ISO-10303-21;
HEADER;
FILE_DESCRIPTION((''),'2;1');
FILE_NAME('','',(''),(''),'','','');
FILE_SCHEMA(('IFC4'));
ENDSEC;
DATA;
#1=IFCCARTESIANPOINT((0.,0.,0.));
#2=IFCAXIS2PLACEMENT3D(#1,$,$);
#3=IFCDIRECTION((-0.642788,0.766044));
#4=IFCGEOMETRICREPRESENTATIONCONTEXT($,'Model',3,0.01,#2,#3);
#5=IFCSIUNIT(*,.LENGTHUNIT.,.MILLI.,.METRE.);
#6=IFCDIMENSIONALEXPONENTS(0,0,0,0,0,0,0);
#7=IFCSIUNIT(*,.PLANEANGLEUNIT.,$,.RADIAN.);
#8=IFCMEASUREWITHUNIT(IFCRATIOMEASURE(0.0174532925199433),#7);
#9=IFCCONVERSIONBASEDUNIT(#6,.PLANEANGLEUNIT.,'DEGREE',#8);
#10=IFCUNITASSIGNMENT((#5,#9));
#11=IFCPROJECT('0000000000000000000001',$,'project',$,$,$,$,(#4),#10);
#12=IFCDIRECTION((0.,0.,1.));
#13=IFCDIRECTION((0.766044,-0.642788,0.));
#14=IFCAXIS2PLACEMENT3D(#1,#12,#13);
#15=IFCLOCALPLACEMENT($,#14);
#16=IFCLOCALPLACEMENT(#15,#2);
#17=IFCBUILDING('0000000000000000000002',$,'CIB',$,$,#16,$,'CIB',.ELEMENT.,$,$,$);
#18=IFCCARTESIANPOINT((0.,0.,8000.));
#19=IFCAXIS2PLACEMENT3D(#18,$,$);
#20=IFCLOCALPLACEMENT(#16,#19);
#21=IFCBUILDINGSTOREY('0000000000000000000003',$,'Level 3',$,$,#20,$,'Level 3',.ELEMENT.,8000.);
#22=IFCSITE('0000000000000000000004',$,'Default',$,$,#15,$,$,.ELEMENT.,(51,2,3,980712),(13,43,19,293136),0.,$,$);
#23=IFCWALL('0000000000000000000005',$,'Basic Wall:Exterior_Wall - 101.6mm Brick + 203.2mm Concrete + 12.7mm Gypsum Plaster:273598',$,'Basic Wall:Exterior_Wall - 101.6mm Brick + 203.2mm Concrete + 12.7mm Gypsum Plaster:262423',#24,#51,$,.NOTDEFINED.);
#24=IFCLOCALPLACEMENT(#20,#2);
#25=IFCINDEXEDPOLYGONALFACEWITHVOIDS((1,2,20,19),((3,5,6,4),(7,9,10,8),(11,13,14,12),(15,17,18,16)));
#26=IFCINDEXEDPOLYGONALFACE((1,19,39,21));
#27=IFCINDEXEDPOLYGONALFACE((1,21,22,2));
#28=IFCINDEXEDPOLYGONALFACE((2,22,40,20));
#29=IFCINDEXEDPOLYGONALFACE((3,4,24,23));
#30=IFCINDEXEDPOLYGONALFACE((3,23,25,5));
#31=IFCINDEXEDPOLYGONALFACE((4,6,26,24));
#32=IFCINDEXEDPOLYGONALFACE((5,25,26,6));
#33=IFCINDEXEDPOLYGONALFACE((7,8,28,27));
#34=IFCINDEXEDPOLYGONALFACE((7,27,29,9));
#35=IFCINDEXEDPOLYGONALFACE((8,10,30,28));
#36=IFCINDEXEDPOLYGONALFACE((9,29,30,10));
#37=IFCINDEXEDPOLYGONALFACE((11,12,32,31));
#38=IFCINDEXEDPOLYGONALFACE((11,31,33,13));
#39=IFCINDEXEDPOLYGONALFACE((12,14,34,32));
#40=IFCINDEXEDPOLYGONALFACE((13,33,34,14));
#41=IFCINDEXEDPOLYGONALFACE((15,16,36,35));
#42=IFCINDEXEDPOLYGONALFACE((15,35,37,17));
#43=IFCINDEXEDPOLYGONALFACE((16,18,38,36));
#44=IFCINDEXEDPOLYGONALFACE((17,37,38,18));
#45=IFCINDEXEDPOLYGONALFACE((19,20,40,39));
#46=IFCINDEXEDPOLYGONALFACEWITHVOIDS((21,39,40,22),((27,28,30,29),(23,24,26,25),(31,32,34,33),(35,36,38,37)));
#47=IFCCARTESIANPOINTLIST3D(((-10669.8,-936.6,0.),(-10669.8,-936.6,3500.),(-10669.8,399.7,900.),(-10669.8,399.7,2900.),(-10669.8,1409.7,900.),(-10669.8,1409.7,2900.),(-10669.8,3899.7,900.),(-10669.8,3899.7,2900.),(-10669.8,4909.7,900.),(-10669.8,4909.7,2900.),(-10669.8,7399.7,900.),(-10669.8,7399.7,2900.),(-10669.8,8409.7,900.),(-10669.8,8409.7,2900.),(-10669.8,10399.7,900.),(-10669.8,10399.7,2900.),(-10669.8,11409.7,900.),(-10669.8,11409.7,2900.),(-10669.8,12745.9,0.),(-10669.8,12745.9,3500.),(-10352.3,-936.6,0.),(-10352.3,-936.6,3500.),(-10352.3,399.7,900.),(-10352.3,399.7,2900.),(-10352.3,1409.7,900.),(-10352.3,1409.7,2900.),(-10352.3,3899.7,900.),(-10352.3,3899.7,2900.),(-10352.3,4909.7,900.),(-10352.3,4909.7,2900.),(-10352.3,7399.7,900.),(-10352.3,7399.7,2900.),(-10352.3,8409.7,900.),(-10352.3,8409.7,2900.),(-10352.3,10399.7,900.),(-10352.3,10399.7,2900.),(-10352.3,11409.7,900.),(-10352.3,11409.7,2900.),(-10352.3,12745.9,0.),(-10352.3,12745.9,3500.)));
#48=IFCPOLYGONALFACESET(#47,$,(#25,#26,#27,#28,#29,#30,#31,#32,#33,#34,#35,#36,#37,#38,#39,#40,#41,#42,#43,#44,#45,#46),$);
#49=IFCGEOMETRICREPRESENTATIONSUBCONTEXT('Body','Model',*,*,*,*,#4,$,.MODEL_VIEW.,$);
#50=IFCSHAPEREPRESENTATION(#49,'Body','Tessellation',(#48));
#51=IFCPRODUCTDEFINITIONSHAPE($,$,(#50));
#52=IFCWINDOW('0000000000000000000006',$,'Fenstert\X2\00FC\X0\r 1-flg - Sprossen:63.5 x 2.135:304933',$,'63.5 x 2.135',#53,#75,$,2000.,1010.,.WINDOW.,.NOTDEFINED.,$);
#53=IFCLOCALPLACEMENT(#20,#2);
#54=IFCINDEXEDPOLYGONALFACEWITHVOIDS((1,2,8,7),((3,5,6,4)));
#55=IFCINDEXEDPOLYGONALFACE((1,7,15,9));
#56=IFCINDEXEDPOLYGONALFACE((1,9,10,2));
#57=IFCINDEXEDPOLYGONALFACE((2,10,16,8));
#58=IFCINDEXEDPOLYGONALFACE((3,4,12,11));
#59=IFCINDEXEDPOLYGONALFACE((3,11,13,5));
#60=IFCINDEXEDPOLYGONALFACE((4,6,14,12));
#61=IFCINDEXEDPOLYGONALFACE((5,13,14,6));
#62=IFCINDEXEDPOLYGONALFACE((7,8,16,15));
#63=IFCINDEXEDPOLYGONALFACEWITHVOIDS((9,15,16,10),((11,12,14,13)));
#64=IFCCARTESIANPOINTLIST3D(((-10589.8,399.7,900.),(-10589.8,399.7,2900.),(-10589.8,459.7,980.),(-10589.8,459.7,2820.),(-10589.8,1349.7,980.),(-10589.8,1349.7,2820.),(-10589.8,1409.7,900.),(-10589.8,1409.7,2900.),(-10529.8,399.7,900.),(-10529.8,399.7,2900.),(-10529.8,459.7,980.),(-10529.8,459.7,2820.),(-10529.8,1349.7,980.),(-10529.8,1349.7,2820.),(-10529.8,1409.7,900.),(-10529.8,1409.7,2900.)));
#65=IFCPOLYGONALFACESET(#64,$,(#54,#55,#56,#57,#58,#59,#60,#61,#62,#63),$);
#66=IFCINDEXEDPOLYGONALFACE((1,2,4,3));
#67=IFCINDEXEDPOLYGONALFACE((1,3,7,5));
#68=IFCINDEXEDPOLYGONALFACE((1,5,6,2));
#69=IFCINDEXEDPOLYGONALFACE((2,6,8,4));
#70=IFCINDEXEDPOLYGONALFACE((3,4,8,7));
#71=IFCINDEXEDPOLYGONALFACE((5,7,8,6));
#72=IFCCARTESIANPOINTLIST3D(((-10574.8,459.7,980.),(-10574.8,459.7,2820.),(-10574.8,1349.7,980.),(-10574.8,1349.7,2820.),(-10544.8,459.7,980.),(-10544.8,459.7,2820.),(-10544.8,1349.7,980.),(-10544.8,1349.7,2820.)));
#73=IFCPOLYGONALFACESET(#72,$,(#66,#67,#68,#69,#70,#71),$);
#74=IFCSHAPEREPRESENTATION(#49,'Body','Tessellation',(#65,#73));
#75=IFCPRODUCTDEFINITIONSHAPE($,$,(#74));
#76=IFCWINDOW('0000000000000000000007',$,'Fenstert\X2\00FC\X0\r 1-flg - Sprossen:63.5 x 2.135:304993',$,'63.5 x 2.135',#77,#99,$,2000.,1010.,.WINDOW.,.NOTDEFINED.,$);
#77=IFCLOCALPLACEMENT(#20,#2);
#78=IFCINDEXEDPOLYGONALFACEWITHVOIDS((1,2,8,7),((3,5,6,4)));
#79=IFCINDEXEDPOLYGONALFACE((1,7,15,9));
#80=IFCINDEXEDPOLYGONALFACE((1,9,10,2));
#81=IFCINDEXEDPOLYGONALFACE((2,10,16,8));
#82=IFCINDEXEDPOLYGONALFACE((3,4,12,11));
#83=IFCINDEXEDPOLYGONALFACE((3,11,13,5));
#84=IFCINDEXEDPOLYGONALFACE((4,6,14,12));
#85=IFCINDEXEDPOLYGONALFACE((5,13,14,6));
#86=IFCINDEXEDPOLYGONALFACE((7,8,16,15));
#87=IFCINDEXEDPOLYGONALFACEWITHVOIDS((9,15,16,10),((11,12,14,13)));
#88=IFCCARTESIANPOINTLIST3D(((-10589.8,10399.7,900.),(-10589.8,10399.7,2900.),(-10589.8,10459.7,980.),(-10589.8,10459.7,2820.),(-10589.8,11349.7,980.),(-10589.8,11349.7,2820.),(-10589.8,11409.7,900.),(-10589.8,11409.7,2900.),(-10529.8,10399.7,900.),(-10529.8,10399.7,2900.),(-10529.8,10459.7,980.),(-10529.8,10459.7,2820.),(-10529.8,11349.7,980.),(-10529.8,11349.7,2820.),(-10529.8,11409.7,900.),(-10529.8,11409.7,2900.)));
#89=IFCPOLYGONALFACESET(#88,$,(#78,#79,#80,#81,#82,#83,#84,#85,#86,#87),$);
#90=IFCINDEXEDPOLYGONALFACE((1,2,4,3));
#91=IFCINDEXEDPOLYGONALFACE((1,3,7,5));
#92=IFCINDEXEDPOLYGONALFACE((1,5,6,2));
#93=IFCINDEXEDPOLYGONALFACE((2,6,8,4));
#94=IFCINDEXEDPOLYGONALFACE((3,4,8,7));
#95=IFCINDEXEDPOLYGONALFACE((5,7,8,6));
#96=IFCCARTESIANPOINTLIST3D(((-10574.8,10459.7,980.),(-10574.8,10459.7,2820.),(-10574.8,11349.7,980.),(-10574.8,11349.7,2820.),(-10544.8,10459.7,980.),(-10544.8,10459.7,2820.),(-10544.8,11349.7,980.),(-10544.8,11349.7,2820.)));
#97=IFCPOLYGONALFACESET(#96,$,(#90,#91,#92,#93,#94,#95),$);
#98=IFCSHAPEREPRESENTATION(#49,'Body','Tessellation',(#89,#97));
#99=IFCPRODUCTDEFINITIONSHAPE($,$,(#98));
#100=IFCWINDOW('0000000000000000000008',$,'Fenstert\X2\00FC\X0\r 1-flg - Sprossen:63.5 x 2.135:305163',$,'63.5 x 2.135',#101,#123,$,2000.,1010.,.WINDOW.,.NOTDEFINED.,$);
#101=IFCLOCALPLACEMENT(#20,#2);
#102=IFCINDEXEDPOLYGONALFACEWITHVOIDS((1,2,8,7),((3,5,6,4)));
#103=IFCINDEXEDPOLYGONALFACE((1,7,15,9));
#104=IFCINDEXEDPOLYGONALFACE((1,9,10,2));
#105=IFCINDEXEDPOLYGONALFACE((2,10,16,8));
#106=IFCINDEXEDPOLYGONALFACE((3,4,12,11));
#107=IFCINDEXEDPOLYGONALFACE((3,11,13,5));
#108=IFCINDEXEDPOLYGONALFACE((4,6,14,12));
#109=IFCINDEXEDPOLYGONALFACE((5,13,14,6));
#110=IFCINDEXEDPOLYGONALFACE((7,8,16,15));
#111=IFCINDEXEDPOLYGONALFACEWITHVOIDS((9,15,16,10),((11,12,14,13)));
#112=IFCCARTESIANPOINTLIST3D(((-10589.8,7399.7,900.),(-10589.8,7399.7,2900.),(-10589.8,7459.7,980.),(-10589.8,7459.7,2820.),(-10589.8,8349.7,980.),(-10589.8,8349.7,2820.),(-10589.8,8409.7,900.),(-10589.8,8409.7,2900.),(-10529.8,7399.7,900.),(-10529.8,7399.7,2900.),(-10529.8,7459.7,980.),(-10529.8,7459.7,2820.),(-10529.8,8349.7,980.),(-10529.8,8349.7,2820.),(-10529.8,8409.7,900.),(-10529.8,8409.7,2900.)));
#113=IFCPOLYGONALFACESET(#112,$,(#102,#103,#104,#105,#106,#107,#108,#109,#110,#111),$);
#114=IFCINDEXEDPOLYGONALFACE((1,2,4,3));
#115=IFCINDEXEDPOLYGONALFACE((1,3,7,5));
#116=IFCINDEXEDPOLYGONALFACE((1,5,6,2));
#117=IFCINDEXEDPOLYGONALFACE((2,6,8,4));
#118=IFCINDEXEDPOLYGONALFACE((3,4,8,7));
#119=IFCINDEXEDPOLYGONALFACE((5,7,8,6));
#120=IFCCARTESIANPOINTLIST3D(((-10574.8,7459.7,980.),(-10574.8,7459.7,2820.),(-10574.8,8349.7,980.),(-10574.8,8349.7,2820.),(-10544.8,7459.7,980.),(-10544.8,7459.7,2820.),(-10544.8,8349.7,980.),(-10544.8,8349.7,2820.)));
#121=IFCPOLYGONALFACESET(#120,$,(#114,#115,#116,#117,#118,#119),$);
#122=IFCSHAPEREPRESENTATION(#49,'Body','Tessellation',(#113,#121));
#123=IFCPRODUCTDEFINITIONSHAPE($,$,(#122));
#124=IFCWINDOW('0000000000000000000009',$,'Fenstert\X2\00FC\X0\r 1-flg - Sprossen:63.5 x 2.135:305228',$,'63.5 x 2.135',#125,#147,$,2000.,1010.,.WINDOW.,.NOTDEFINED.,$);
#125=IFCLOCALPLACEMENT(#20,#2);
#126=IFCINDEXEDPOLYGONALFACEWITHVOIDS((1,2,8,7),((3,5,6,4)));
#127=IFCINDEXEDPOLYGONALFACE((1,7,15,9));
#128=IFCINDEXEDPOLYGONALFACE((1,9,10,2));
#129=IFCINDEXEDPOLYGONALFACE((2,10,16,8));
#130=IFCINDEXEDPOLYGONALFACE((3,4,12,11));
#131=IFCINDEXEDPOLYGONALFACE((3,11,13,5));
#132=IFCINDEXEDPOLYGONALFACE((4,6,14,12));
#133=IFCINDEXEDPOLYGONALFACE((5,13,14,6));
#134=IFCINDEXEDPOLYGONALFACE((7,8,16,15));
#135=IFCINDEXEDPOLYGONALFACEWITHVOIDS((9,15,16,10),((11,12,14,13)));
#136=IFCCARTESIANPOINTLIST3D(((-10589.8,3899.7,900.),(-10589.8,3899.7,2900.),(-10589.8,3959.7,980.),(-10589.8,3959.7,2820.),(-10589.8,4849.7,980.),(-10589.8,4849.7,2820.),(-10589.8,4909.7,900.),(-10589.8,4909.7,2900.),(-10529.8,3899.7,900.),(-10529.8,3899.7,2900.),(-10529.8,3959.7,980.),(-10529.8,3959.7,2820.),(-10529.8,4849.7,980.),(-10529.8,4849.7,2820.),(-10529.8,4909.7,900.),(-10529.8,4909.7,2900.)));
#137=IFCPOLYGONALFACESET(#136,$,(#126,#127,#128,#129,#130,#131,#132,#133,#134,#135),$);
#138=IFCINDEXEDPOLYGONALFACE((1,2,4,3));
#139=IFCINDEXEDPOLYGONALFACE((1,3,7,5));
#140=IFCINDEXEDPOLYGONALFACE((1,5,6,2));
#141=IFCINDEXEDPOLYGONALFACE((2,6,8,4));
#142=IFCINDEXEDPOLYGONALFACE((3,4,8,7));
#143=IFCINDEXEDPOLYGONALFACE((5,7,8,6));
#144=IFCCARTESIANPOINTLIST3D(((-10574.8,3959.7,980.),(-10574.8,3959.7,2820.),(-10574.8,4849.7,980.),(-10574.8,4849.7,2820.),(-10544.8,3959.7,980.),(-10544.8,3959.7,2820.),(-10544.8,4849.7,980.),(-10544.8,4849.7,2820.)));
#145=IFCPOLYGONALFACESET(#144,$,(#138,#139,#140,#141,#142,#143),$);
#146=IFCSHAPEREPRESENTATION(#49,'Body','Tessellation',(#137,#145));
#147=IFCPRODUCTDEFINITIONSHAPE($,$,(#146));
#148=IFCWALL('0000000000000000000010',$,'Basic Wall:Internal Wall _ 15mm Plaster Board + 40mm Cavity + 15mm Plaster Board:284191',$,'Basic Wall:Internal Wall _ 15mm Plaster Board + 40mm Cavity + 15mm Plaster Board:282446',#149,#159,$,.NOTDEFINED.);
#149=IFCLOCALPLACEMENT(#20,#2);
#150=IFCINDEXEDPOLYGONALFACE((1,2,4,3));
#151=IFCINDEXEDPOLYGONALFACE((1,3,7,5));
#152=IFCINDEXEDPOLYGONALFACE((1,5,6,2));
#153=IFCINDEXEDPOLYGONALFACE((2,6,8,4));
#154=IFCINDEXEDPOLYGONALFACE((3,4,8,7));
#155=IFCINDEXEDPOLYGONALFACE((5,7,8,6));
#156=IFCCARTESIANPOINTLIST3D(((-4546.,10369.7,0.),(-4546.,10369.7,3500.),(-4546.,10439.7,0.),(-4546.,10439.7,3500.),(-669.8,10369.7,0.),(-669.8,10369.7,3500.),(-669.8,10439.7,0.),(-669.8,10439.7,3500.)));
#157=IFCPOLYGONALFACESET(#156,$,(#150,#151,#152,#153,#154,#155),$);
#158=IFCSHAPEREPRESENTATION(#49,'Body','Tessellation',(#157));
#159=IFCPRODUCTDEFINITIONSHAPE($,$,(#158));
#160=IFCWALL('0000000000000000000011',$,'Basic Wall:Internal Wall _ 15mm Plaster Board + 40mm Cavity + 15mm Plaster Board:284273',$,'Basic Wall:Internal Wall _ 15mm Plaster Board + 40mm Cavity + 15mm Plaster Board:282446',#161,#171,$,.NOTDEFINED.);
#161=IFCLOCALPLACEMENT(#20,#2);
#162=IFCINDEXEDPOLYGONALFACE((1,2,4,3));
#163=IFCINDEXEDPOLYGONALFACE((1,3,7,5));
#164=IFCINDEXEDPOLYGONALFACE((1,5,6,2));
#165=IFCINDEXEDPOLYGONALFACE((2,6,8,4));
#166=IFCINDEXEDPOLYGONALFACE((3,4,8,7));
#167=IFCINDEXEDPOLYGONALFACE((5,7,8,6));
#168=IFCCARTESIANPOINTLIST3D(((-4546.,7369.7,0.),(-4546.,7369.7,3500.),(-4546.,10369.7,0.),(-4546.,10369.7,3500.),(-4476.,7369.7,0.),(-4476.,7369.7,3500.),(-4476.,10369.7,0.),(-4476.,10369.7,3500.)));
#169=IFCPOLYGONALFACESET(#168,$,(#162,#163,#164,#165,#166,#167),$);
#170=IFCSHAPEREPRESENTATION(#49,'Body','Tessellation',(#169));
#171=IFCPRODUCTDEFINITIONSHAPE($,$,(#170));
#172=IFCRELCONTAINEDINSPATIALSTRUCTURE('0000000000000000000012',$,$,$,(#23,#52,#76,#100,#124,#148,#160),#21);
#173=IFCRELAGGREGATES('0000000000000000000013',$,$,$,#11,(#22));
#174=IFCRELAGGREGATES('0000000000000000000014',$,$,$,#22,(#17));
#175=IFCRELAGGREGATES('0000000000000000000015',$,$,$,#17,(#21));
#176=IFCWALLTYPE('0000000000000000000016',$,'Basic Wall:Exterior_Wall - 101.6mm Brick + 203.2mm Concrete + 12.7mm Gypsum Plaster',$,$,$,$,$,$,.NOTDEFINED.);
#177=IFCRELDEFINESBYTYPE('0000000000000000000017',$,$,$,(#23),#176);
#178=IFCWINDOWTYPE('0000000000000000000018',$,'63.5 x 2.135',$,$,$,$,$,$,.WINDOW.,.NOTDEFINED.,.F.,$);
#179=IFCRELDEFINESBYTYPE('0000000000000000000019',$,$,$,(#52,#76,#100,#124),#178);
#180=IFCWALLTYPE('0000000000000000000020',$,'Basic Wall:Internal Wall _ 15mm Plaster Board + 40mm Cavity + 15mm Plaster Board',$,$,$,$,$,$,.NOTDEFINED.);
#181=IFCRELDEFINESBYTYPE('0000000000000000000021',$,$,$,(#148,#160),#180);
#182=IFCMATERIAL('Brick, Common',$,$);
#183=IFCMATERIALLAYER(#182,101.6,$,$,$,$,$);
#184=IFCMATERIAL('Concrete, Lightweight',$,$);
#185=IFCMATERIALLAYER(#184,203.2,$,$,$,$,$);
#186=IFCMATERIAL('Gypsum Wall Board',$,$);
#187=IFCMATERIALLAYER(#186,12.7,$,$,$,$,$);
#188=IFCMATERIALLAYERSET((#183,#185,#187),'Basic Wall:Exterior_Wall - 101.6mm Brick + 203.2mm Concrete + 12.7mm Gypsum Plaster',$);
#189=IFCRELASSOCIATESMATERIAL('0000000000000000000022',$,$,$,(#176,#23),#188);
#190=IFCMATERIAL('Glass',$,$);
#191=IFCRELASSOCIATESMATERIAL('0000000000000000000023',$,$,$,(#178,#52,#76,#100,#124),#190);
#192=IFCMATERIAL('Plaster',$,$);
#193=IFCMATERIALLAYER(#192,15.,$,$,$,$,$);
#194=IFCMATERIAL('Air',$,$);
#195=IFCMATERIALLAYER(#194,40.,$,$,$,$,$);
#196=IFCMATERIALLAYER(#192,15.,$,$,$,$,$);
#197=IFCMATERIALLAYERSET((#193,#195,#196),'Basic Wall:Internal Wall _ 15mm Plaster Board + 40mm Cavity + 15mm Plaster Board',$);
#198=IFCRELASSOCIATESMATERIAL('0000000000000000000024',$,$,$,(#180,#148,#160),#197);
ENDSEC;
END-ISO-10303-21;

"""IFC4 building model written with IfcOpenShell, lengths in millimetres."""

from ifc_helpers import new_model, entity, si_unit, converted_unit, direction, frame, frame_2d, origin, origin_2d_with_axis, place, context, subcontext, project, spatial, polyline, rectangle, outline, extrude, source, transform, mapped, material, layer, layer_set, layer_usage, type_object, type_shapes, element, fill, save


model = new_model("IFC4")

# Units and contexts
model_context = context("Model", 3, precision=0.01, world=origin(), true_north=direction((-0.642788, 0.766044)))
body_context = subcontext(model_context, "Body", "Model", "MODEL_VIEW")
ifc_project = project(units=[si_unit("LENGTHUNIT", "METRE", prefix="MILLI"), converted_unit("PLANEANGLEUNIT", "DEGREE", entity("IfcRatioMeasure", 0.0174532925199433), si_unit("PLANEANGLEUNIT", "RADIAN"), dimensions=[0, 0, 0, 0, 0, 0, 0])], contexts=[model_context])

# Site, building, storey
site_placement = place(None, frame((0.0, 0.0, 0.0), z_axis=(0.0, 0.0, 1.0), x_axis=(0.766044, -0.642788, 0.0)))
site = spatial("IfcSite", under=ifc_project, at=site_placement, Name="Default", CompositionType="ELEMENT", RefLatitude=(51, 2, 3, 980712), RefLongitude=(13, 43, 19, 293136), RefElevation=0.0)
building_placement = place(site_placement, origin())
building = spatial("IfcBuilding", under=site, at=building_placement, Name="CIB", LongName="CIB", CompositionType="ELEMENT")
storey_placement = place(building_placement, frame((0.0, 0.0, 8000.0)))
storey = spatial("IfcBuildingStorey", under=building, at=storey_placement, Name="Level 3", LongName="Level 3", CompositionType="ELEMENT", Elevation=8000.0)

# Shared definitions
ifc_material_1 = material(Name="Brick, Common")
ifc_layer_1 = layer(ifc_material_1, 101.6)
ifc_material_2 = material(Name="Concrete, Lightweight")
ifc_layer_2 = layer(ifc_material_2, 203.2)
ifc_material_3 = material(Name="Gypsum Wall Board")
ifc_layer_3 = layer(ifc_material_3, 12.7)
ifc_layer_set_1 = layer_set([ifc_layer_1, ifc_layer_2, ifc_layer_3], Name="Basic Wall:Exterior_Wall - 101.6mm Brick + 203.2mm Concrete + 12.7mm Gypsum Plaster")
wall_type_1 = type_object("IfcWallType", Name="Basic Wall:Exterior_Wall - 101.6mm Brick + 203.2mm Concrete + 12.7mm Gypsum Plaster", PredefinedType="NOTDEFINED", material=ifc_layer_set_1)
ifc_material_4 = material(Name="Glass")
window_type = type_object("IfcWindowType", Name="63.5 x 2.135", ParameterTakesPrecedence=False, PartitioningType="NOTDEFINED", PredefinedType="WINDOW", material=ifc_material_4)
shared_shape_1 = source(origin(), body_context, "Body", "SweptSolid", [
    extrude(outline(polyline([(-1000.0, -505.0), (1000.0, -505.0), (1000.0, 505.0), (-1000.0, 505.0), (-1000.0, -505.0)]), holes=[polyline([(-920.0, -445.0), (-920.0, 445.0), (920.0, 445.0), (920.0, -445.0), (-920.0, -445.0)])]), frame((505.0, 177.5, 1000.0), z_axis=(0.0, 1.0, 0.0), x_axis=(0.0, 0.0, -1.0)), (0.0, 0.0, 1.0), 60.0),
    extrude(rectangle(XDim=30.0, YDim=890.0, at=origin_2d_with_axis()), frame((505.0, 207.5, 80.0), z_axis=(0.0, 0.0, 1.0), x_axis=(0.0, 1.0, 0.0)), (0.0, 0.0, 1.0), 1840.0),
])
type_shapes(window_type, [shared_shape_1])

# Wall, openings, windows
ifc_layer_usage_1 = layer_usage(ifc_layer_set_1, "AXIS2", "NEGATIVE", 158.8)
wall_1_placement = place(storey_placement, frame((-10511.0, -936.6, 0.0), z_axis=(0.0, 0.0, 1.0), x_axis=(0.0, 1.0, 0.0)))
wall_1 = element("IfcWall", 1, at=wall_1_placement, inside=storey, type_object=wall_type_1, material=ifc_layer_usage_1, Name="Basic Wall:Exterior_Wall - 101.6mm Brick + 203.2mm Concrete + 12.7mm Gypsum Plaster:273598", ObjectType="Basic Wall:Exterior_Wall - 101.6mm Brick + 203.2mm Concrete + 12.7mm Gypsum Plaster:262423", PredefinedType="NOTDEFINED", context=body_context, shape_type="SweptSolid", body=[
    extrude(rectangle(XDim=13682.5, YDim=317.5, at=frame_2d((6841.2, 0.0), x_axis=(-1.0, 0.0))), origin(), (0.0, 0.0, 1.0), 3500.0),
])
opening_1_placement = place(wall_1_placement, frame((2346.2, 158.8, 900.0)))
opening_1 = element("IfcOpeningElement", 2, at=opening_1_placement, cuts=wall_1, ObjectType="Opening", PredefinedType="OPENING", context=body_context, shape_type="SweptSolid", body=[
    extrude(rectangle(XDim=2000.0, YDim=1010.0, at=frame_2d((1000.0, 505.0), x_axis=(1.0, 0.0))), frame((0.0, 0.0, 0.0), z_axis=(0.0, -1.0, 0.0), x_axis=(0.0, 0.0, 1.0)), (0.0, 0.0, 1.0), 317.5),
])
opening_2_placement = place(wall_1_placement, frame((12346.2, 158.8, 900.0)))
opening_2 = element("IfcOpeningElement", 3, at=opening_2_placement, cuts=wall_1, ObjectType="Opening", PredefinedType="OPENING", context=body_context, shape_type="SweptSolid", body=[
    extrude(rectangle(XDim=2000.0, YDim=1010.0, at=frame_2d((1000.0, 505.0), x_axis=(1.0, 0.0))), frame((0.0, 0.0, 0.0), z_axis=(0.0, -1.0, 0.0), x_axis=(0.0, 0.0, 1.0)), (0.0, 0.0, 1.0), 317.5),
])
opening_3_placement = place(wall_1_placement, frame((9346.2, 158.8, 900.0)))
opening_3 = element("IfcOpeningElement", 4, at=opening_3_placement, cuts=wall_1, ObjectType="Opening", PredefinedType="OPENING", context=body_context, shape_type="SweptSolid", body=[
    extrude(rectangle(XDim=2000.0, YDim=1010.0, at=frame_2d((1000.0, 505.0), x_axis=(1.0, 0.0))), frame((0.0, 0.0, 0.0), z_axis=(0.0, -1.0, 0.0), x_axis=(0.0, 0.0, 1.0)), (0.0, 0.0, 1.0), 317.5),
])
opening_4_placement = place(wall_1_placement, frame((5846.2, 158.8, 900.0)))
opening_4 = element("IfcOpeningElement", 5, at=opening_4_placement, cuts=wall_1, ObjectType="Opening", PredefinedType="OPENING", context=body_context, shape_type="SweptSolid", body=[
    extrude(rectangle(XDim=2000.0, YDim=1010.0, at=frame_2d((1000.0, 505.0), x_axis=(1.0, 0.0))), frame((0.0, 0.0, 0.0), z_axis=(0.0, -1.0, 0.0), x_axis=(0.0, 0.0, 1.0)), (0.0, 0.0, 1.0), 317.5),
])
window_1_placement = place(opening_1_placement, frame((-1010.0, -317.5, 0.0)))
window_1 = element("IfcWindow", 6, at=window_1_placement, inside=storey, type_object=window_type, material=ifc_material_4, Name="Fenstertür 1-flg - Sprossen:63.5 x 2.135:304933", ObjectType="63.5 x 2.135", OverallHeight=2000.0, OverallWidth=1010.0, PartitioningType="NOTDEFINED", PredefinedType="WINDOW", context=body_context, shape_type="MappedRepresentation", body=[
    mapped(shared_shape_1, transform((0.0, 0.0, 0.0), scale=1.0)),
])
fill(opening_1, window_1)
window_2_placement = place(opening_2_placement, frame((-1010.0, -317.5, 0.0)))
window_2 = element("IfcWindow", 7, at=window_2_placement, inside=storey, type_object=window_type, material=ifc_material_4, Name="Fenstertür 1-flg - Sprossen:63.5 x 2.135:304993", ObjectType="63.5 x 2.135", OverallHeight=2000.0, OverallWidth=1010.0, PartitioningType="NOTDEFINED", PredefinedType="WINDOW", context=body_context, shape_type="MappedRepresentation", body=[
    mapped(shared_shape_1, transform((0.0, 0.0, 0.0), scale=1.0)),
])
fill(opening_2, window_2)
window_3_placement = place(opening_3_placement, frame((-1010.0, -317.5, 0.0)))
window_3 = element("IfcWindow", 8, at=window_3_placement, inside=storey, type_object=window_type, material=ifc_material_4, Name="Fenstertür 1-flg - Sprossen:63.5 x 2.135:305163", ObjectType="63.5 x 2.135", OverallHeight=2000.0, OverallWidth=1010.0, PartitioningType="NOTDEFINED", PredefinedType="WINDOW", context=body_context, shape_type="MappedRepresentation", body=[
    mapped(shared_shape_1, transform((0.0, 0.0, 0.0), scale=1.0)),
])
fill(opening_3, window_3)
window_4_placement = place(opening_4_placement, frame((-1010.0, -317.5, 0.0)))
window_4 = element("IfcWindow", 9, at=window_4_placement, inside=storey, type_object=window_type, material=ifc_material_4, Name="Fenstertür 1-flg - Sprossen:63.5 x 2.135:305228", ObjectType="63.5 x 2.135", OverallHeight=2000.0, OverallWidth=1010.0, PartitioningType="NOTDEFINED", PredefinedType="WINDOW", context=body_context, shape_type="MappedRepresentation", body=[
    mapped(shared_shape_1, transform((0.0, 0.0, 0.0), scale=1.0)),
])
fill(opening_4, window_4)

# Walls
ifc_material_5 = material(Name="Plaster")
ifc_layer_4 = layer(ifc_material_5, 15.0)
ifc_material_6 = material(Name="Air")
ifc_layer_5 = layer(ifc_material_6, 40.0)
ifc_layer_6 = layer(ifc_material_5, 15.0)
ifc_layer_set_2 = layer_set([ifc_layer_4, ifc_layer_5, ifc_layer_6], Name="Basic Wall:Internal Wall _ 15mm Plaster Board + 40mm Cavity + 15mm Plaster Board")
ifc_layer_usage_2 = layer_usage(ifc_layer_set_2, "AXIS2", "NEGATIVE", 35.0)
wall_type_2 = type_object("IfcWallType", Name="Basic Wall:Internal Wall _ 15mm Plaster Board + 40mm Cavity + 15mm Plaster Board", PredefinedType="NOTDEFINED", material=ifc_layer_set_2)
wall_2_placement = place(storey_placement, frame((-669.8, 10404.7, 0.0), z_axis=(0.0, 0.0, 1.0), x_axis=(-1.0, 0.0, 0.0)))
element("IfcWall", 10, at=wall_2_placement, inside=storey, type_object=wall_type_2, material=ifc_layer_usage_2, Name="Basic Wall:Internal Wall _ 15mm Plaster Board + 40mm Cavity + 15mm Plaster Board:284191", ObjectType="Basic Wall:Internal Wall _ 15mm Plaster Board + 40mm Cavity + 15mm Plaster Board:282446", PredefinedType="NOTDEFINED", context=body_context, shape_type="SweptSolid", body=[
    extrude(rectangle(XDim=3876.2, YDim=70.0, at=frame_2d((1938.1, 0.0), x_axis=(-1.0, 0.0))), origin(), (0.0, 0.0, 1.0), 3500.0),
])
ifc_layer_usage_3 = layer_usage(ifc_layer_set_2, "AXIS2", "NEGATIVE", 35.0)
wall_3_placement = place(storey_placement, frame((-4511.0, 10369.7, 0.0), z_axis=(0.0, 0.0, 1.0), x_axis=(0.0, -1.0, 0.0)))
element("IfcWall", 11, at=wall_3_placement, inside=storey, type_object=wall_type_2, material=ifc_layer_usage_3, Name="Basic Wall:Internal Wall _ 15mm Plaster Board + 40mm Cavity + 15mm Plaster Board:284273", ObjectType="Basic Wall:Internal Wall _ 15mm Plaster Board + 40mm Cavity + 15mm Plaster Board:282446", PredefinedType="NOTDEFINED", context=body_context, shape_type="SweptSolid", body=[
    extrude(rectangle(XDim=3000.0, YDim=70.0, at=frame_2d((1500.0, 0.0), x_axis=(-1.0, 0.0))), origin(), (0.0, 0.0, 1.0), 3500.0),
])

save(model, "model.ifc")
